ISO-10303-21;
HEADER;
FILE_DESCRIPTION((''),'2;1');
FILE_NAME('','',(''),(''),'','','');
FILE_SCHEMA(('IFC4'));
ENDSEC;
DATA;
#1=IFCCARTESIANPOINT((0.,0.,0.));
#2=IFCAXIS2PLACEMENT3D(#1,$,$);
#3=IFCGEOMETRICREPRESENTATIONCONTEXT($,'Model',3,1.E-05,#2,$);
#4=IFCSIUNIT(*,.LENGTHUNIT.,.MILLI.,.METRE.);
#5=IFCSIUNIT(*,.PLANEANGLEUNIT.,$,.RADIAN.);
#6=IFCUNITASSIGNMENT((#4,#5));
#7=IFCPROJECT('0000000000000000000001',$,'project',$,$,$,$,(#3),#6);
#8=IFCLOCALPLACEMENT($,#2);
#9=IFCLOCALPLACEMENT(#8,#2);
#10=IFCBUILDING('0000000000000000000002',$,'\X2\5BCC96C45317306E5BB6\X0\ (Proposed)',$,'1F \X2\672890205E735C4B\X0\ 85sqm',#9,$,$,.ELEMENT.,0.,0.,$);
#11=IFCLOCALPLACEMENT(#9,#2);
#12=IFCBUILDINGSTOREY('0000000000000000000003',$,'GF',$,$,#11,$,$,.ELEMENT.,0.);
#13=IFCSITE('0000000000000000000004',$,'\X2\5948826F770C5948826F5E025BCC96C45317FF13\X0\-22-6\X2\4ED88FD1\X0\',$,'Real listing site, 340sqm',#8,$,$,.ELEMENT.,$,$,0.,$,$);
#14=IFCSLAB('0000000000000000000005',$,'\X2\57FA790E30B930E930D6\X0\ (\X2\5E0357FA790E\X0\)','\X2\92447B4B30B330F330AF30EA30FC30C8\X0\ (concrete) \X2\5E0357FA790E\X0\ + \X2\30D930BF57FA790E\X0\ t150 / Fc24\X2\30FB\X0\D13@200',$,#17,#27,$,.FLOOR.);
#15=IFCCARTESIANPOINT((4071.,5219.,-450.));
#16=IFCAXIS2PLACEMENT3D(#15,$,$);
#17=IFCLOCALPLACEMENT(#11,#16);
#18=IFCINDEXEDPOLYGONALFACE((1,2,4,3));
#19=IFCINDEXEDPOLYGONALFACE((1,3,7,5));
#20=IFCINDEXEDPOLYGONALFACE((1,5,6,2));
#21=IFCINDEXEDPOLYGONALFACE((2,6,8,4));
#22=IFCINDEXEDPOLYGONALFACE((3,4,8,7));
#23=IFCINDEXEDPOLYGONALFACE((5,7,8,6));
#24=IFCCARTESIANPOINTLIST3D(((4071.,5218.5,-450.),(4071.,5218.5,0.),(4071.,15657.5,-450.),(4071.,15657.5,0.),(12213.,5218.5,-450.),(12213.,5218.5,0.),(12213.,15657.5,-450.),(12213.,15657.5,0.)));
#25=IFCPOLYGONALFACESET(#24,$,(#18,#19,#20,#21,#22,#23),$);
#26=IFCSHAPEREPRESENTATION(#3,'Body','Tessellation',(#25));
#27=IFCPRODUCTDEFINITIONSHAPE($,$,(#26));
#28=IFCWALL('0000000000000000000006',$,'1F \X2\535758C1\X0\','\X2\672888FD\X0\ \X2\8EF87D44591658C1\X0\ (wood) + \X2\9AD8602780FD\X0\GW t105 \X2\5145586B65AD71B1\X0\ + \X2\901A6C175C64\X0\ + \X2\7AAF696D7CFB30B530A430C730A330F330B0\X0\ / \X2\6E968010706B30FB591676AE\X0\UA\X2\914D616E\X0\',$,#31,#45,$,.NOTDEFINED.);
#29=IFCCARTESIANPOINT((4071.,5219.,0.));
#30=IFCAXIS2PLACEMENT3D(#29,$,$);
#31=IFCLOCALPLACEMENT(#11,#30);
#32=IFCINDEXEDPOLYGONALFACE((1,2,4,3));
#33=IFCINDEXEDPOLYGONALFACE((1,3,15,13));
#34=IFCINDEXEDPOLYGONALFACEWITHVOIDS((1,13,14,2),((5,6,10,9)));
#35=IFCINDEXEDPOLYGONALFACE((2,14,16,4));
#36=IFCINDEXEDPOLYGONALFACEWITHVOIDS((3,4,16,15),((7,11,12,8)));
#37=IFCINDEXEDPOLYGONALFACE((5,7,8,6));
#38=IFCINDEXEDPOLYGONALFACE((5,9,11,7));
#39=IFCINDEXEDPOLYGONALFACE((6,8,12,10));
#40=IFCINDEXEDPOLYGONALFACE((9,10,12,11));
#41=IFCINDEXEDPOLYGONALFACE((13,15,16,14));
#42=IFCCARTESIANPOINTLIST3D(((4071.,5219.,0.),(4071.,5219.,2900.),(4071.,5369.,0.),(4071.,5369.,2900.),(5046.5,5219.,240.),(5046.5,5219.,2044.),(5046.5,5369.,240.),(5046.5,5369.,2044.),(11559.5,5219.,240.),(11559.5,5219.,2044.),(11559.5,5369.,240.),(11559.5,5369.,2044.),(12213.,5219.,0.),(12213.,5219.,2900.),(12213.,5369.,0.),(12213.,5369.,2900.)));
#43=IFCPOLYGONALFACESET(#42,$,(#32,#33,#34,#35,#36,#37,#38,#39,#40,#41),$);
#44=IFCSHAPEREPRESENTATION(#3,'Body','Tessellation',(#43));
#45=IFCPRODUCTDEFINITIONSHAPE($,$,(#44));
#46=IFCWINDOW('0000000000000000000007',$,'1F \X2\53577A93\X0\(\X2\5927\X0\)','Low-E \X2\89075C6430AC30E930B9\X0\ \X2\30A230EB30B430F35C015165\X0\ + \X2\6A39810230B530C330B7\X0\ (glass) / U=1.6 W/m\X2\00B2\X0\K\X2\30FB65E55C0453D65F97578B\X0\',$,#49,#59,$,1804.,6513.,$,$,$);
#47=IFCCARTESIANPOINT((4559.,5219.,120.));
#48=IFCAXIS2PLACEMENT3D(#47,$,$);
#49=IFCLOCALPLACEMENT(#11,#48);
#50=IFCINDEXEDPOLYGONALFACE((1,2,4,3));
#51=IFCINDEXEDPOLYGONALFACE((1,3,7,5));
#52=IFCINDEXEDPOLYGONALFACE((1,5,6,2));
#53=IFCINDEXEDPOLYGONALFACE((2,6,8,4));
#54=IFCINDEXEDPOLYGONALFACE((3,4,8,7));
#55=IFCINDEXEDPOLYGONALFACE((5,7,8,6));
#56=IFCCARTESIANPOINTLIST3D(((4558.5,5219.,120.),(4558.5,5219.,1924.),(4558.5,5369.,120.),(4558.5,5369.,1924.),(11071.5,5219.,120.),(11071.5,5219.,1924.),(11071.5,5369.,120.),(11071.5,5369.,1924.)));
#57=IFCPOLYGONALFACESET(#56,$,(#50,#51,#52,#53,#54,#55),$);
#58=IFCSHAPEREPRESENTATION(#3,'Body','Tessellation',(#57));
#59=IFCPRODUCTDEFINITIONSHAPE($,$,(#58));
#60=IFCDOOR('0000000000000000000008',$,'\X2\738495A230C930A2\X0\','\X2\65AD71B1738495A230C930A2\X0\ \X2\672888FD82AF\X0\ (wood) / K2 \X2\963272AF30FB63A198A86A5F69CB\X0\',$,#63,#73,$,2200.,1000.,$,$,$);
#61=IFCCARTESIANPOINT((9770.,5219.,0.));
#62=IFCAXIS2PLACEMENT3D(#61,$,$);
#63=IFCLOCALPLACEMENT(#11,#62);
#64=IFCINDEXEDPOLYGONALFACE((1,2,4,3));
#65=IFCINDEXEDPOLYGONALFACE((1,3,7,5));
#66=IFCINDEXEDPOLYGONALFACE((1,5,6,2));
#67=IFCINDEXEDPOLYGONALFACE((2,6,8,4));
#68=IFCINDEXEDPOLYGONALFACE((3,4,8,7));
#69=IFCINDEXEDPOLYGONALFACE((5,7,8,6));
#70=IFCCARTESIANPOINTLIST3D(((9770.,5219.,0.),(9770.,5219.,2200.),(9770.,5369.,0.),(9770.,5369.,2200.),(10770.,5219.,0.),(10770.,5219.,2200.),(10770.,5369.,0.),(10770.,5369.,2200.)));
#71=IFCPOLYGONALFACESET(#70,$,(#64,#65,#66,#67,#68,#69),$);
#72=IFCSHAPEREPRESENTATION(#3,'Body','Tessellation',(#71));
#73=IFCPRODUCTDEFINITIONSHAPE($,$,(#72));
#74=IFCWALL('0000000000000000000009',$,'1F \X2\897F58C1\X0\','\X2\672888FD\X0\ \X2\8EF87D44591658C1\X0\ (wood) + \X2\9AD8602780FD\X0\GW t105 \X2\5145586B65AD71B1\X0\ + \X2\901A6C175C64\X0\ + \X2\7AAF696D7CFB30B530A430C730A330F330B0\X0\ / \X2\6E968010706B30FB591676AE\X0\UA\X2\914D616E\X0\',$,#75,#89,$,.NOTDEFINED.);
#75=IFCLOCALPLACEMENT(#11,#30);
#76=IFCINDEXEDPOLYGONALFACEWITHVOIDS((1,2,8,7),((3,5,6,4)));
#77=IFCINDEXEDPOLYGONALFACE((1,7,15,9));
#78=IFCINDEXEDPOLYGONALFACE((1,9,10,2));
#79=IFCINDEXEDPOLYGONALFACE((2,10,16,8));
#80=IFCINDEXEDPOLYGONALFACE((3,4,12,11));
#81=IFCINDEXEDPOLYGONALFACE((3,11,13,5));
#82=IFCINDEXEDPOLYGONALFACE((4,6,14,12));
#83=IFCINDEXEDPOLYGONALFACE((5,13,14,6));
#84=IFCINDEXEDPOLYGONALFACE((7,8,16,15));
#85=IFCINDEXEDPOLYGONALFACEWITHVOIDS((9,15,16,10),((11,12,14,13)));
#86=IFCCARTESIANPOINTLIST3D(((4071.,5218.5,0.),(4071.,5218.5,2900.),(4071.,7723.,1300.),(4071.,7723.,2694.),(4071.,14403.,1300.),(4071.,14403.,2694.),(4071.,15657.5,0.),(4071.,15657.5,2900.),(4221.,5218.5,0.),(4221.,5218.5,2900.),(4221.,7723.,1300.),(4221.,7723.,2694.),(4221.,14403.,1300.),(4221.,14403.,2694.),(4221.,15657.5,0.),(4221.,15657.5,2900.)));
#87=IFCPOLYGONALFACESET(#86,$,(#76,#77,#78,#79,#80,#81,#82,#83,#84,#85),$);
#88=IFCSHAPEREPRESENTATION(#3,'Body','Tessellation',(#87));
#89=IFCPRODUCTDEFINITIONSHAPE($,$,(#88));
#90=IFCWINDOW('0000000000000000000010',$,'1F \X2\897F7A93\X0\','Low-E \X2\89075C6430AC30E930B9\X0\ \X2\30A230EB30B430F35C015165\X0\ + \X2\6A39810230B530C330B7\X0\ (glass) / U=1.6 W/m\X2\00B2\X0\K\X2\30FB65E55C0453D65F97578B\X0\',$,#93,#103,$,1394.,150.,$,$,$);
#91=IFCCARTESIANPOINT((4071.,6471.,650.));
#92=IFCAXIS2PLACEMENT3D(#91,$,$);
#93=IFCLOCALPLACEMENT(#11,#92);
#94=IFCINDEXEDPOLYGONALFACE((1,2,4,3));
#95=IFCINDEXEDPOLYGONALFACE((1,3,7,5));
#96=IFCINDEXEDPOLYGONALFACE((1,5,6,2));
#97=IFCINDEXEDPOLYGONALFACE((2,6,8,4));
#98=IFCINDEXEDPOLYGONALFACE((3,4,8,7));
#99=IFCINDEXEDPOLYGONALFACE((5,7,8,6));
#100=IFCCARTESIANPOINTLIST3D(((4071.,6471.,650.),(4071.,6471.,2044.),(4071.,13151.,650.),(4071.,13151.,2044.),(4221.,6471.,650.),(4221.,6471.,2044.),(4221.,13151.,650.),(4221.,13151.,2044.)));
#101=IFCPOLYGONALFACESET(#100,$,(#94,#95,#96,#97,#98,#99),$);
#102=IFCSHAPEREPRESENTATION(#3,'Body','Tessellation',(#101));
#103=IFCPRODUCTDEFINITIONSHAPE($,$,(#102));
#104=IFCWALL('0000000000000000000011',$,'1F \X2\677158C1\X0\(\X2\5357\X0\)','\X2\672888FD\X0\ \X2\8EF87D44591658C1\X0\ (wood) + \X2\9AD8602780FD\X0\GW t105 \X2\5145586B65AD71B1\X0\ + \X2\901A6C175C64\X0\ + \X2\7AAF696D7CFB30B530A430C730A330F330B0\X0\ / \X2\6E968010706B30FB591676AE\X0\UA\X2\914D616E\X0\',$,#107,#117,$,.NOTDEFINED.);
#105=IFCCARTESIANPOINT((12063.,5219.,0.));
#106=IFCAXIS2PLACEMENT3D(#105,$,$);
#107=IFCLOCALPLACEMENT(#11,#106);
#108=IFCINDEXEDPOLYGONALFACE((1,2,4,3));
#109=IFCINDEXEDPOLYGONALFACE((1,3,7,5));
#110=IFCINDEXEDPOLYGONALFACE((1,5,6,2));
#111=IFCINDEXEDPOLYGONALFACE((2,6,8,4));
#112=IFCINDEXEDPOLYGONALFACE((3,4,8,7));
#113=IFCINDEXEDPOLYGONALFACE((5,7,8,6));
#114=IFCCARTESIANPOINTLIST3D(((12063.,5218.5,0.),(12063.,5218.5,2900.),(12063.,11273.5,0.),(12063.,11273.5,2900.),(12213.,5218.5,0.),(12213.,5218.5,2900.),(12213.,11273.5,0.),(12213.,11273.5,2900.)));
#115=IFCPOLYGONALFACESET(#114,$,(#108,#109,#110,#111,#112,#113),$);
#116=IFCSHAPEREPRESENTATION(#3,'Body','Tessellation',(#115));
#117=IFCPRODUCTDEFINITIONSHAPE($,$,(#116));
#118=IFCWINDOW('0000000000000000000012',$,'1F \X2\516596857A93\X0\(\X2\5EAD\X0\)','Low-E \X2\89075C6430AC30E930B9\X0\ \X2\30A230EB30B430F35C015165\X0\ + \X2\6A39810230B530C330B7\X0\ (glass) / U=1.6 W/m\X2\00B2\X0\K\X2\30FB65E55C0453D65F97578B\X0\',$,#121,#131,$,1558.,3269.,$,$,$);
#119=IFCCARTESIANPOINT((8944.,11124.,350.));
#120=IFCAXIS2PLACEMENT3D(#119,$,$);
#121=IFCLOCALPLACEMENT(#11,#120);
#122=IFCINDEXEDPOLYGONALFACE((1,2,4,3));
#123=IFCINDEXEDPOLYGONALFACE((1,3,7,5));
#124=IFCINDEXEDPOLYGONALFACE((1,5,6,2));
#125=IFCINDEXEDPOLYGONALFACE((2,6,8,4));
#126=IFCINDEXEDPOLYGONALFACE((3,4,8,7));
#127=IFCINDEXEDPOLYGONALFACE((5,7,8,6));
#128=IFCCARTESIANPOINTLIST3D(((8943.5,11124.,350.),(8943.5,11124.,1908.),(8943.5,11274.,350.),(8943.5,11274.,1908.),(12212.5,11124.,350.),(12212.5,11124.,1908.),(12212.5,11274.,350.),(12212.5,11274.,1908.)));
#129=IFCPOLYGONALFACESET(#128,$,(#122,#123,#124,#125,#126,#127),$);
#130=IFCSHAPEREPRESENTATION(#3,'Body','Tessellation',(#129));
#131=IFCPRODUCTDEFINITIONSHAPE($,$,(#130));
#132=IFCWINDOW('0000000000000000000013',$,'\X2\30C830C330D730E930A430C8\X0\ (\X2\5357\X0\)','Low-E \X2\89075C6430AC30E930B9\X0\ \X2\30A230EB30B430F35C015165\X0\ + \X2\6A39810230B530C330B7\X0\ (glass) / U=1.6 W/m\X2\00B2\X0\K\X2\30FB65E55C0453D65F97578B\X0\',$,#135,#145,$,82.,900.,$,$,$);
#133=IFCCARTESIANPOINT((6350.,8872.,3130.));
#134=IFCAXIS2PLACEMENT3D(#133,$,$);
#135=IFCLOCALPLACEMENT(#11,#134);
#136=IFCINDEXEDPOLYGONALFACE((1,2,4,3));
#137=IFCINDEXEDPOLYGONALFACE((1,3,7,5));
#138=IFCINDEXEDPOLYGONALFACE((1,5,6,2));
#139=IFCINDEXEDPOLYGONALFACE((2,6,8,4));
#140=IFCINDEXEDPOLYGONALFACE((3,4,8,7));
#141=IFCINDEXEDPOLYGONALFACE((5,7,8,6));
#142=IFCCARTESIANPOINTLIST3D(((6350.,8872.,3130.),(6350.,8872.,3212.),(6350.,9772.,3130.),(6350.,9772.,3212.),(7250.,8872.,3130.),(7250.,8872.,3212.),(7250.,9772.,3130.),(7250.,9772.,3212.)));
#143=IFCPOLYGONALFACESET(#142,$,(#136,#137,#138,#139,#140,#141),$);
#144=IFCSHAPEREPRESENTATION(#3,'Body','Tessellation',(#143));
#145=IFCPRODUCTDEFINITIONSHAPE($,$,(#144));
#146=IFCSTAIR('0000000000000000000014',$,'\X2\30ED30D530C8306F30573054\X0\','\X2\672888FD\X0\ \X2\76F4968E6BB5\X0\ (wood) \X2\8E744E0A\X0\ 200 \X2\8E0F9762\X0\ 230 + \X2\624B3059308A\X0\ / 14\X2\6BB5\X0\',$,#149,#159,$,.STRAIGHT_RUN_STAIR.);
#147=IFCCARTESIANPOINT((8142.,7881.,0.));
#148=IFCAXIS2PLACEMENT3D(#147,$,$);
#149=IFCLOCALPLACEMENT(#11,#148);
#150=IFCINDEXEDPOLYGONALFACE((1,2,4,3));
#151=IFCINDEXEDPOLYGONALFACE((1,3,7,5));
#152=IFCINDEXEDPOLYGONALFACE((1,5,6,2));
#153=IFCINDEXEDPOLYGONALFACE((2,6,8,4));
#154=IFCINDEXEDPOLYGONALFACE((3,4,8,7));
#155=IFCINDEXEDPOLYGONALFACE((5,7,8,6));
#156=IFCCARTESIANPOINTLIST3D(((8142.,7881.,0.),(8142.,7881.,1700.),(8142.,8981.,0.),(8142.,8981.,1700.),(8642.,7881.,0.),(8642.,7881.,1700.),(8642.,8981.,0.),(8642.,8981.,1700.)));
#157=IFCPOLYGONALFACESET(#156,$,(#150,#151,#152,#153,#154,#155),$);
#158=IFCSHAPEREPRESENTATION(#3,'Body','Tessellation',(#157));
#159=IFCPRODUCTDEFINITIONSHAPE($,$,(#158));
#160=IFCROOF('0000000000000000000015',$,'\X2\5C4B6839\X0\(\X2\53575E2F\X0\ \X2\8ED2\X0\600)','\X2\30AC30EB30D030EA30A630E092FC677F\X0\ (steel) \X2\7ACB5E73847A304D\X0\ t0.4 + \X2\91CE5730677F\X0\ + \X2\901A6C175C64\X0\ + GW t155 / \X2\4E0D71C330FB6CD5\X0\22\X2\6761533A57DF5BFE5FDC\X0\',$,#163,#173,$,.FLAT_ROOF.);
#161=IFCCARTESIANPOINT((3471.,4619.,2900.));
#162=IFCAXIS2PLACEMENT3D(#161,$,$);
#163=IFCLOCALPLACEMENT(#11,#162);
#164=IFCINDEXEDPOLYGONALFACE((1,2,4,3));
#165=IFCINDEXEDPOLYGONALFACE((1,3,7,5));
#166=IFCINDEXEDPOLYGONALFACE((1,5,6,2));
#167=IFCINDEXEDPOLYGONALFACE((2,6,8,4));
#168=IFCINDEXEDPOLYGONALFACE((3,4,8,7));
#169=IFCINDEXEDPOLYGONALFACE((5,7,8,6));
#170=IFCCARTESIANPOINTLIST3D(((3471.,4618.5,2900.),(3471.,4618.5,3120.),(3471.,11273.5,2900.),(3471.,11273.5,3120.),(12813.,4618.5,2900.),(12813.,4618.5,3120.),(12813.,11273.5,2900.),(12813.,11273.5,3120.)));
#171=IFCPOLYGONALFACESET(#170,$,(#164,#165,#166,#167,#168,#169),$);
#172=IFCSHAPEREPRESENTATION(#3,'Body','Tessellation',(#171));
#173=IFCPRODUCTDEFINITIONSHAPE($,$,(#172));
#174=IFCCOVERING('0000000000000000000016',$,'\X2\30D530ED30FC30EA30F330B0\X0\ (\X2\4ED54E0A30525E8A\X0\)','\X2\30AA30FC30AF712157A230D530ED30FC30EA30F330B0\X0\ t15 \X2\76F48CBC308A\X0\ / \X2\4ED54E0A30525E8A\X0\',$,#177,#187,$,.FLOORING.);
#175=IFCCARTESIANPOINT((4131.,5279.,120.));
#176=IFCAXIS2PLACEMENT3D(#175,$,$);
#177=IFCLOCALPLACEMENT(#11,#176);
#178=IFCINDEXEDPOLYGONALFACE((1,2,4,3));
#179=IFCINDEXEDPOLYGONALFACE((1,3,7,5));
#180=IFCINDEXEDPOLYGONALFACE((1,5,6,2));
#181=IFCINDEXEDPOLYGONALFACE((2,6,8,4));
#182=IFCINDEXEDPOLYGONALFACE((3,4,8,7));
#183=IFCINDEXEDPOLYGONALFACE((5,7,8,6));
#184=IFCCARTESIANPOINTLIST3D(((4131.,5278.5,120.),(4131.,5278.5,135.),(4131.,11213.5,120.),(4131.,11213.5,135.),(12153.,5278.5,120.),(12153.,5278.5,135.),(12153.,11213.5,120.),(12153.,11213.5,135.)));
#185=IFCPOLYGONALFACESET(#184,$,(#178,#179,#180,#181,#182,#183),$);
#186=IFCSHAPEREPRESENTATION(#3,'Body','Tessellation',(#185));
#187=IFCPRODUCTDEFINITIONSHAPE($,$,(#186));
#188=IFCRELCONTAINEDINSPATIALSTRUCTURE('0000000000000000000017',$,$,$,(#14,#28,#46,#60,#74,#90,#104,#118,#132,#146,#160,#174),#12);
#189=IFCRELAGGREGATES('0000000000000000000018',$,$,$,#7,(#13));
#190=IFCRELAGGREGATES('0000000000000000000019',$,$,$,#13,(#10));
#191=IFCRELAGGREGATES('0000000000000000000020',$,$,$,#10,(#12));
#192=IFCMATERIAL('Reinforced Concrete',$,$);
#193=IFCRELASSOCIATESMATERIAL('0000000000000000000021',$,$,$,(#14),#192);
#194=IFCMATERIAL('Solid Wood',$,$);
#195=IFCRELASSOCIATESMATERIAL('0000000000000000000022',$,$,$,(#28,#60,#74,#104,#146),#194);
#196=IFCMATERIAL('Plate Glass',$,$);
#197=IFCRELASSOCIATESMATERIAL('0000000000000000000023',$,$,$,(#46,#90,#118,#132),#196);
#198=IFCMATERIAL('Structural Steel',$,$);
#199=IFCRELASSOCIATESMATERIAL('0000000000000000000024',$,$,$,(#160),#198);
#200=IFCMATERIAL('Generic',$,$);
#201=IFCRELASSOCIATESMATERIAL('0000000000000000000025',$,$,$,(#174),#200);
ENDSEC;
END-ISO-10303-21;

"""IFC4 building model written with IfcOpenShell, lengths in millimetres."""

from ifc_helpers import new_model, si_unit, frame, frame_2d, origin, place, context, project, spatial, rectangle, extrude, material, element, fill, save


model = new_model("IFC4")

# Units and contexts
model_context = context("Model", 3, precision=1e-05, world=origin())
ifc_project = project(units=[si_unit("LENGTHUNIT", "METRE", prefix="MILLI"), si_unit("PLANEANGLEUNIT", "RADIAN")], contexts=[model_context])

# Site, building, storey
site_placement = place(None, origin())
site = spatial("IfcSite", under=ifc_project, at=site_placement, Name="奈良県奈良市富雄北３-22-6付近", ObjectType="Real listing site, 340sqm", CompositionType="ELEMENT", RefElevation=0.0)
building_placement = place(site_placement, origin())
building = spatial("IfcBuilding", under=site, at=building_placement, Name="富雄北の家 (Proposed)", ObjectType="1F 木造平屋 85sqm", CompositionType="ELEMENT", ElevationOfRefHeight=0.0, ElevationOfTerrain=0.0)
storey_placement = place(building_placement, origin())
storey = spatial("IfcBuildingStorey", under=building, at=storey_placement, Name="GF", CompositionType="ELEMENT", Elevation=0.0)

# Slab
ifc_material_1 = material(Name="Reinforced Concrete")
slab_1_placement = place(storey_placement, frame((4071.0, 5219.0, -450.0)))
element("IfcSlab", 1, at=slab_1_placement, inside=storey, material=ifc_material_1, Name="基礎スラブ (布基礎)", Description="鉄筋コンクリート (concrete) 布基礎 + ベタ基礎 t150 / Fc24・D13@200", PredefinedType="FLOOR", context=model_context, shape_type="SweptSolid", body=[
    extrude(rectangle(XDim=8142.0, YDim=10439.0, at=frame_2d((4071.0, 5219.0))), frame((4071.0, 5219.0, -450.0)), (0.0, 0.0, 1.0), 450.0),
])
ifc_material_2 = material(Name="Solid Wood")

# Wall, openings, window, door
wall_1_placement = place(storey_placement, frame((4071.0, 5219.0, 0.0)))
wall_1 = element("IfcWall", 2, at=wall_1_placement, inside=storey, material=ifc_material_2, Name="1F 南壁", Description="木製 軸組外壁 (wood) + 高性能GW t105 充填断熱 + 通気層 + 窯業系サイディング / 準耐火・外皮UA配慮", PredefinedType="NOTDEFINED", context=model_context, shape_type="SweptSolid", body=[
    extrude(rectangle(XDim=8142.0, YDim=150.0, at=frame_2d((4071.0, 75.0))), frame((4071.0, 5219.0, 0.0)), (0.0, 0.0, 1.0), 2900.0),
])
opening_1_placement = place(storey_placement, frame((4559.0, 5219.0, 120.0)))
opening_1 = element("IfcOpeningElement", 3, at=opening_1_placement, cuts=wall_1, PredefinedType="NOTDEFINED", context=model_context, shape_type="SweptSolid", body=[
    extrude(rectangle(XDim=6513.0, YDim=150.0, at=frame_2d((3256.0, 75.0))), frame((4559.0, 5219.0, 120.0)), (0.0, 0.0, 1.0), 1804.0),
])
opening_2_placement = place(storey_placement, frame((9770.0, 5219.0, 0.0)))
opening_2 = element("IfcOpeningElement", 4, at=opening_2_placement, cuts=wall_1, PredefinedType="NOTDEFINED", context=model_context, shape_type="SweptSolid", body=[
    extrude(rectangle(XDim=1000.0, YDim=150.0, at=frame_2d((500.0, 75.0))), frame((9770.0, 5219.0, 0.0)), (0.0, 0.0, 1.0), 2200.0),
])
ifc_material_3 = material(Name="Plate Glass")
window_1_placement = place(storey_placement, frame((4559.0, 5219.0, 120.0)))
window_1 = element("IfcWindow", 5, at=window_1_placement, inside=storey, material=ifc_material_3, Name="1F 南窓(大)", Description="Low-E 複層ガラス アルゴン封入 + 樹脂サッシ (glass) / U=1.6 W/m²K・日射取得型", OverallHeight=1804.0, OverallWidth=6513.0, context=model_context, shape_type="SweptSolid", body=[
    extrude(rectangle(XDim=6513.0, YDim=150.0, at=frame_2d((3256.0, 75.0))), frame((4559.0, 5219.0, 120.0)), (0.0, 0.0, 1.0), 1804.0),
])
fill(opening_1, window_1)
door_1_placement = place(storey_placement, frame((9770.0, 5219.0, 0.0)))
door_1 = element("IfcDoor", 6, at=door_1_placement, inside=storey, material=ifc_material_2, Name="玄関ドア", Description="断熱玄関ドア 木製芯 (wood) / K2 防犯・採風機構", OverallHeight=2200.0, OverallWidth=1000.0, context=model_context, shape_type="SweptSolid", body=[
    extrude(rectangle(XDim=1000.0, YDim=150.0, at=frame_2d((500.0, 75.0))), frame((9770.0, 5219.0, 0.0)), (0.0, 0.0, 1.0), 2200.0),
])
fill(opening_2, door_1)

# Walls, openings, windows
wall_2_placement = place(storey_placement, frame((4071.0, 5219.0, 0.0)))
wall_2 = element("IfcWall", 7, at=wall_2_placement, inside=storey, material=ifc_material_2, Name="1F 西壁", Description="木製 軸組外壁 (wood) + 高性能GW t105 充填断熱 + 通気層 + 窯業系サイディング / 準耐火・外皮UA配慮", PredefinedType="NOTDEFINED", context=model_context, shape_type="SweptSolid", body=[
    extrude(rectangle(XDim=150.0, YDim=10439.0, at=frame_2d((75.0, 5219.0))), frame((4071.0, 5219.0, 0.0)), (0.0, 0.0, 1.0), 2900.0),
])
opening_3_placement = place(storey_placement, frame((4071.0, 6471.0, 650.0)))
opening_3 = element("IfcOpeningElement", 8, at=opening_3_placement, cuts=wall_2, PredefinedType="NOTDEFINED", context=model_context, shape_type="SweptSolid", body=[
    extrude(rectangle(XDim=150.0, YDim=6680.0, at=frame_2d((75.0, 3340.0))), frame((4071.0, 6471.0, 650.0)), (0.0, 0.0, 1.0), 1394.0),
])
window_2_placement = place(storey_placement, frame((4071.0, 6471.0, 650.0)))
window_2 = element("IfcWindow", 9, at=window_2_placement, inside=storey, material=ifc_material_3, Name="1F 西窓", Description="Low-E 複層ガラス アルゴン封入 + 樹脂サッシ (glass) / U=1.6 W/m²K・日射取得型", OverallHeight=1394.0, OverallWidth=150.0, context=model_context, shape_type="SweptSolid", body=[
    extrude(rectangle(XDim=150.0, YDim=6680.0, at=frame_2d((75.0, 3340.0))), frame((4071.0, 6471.0, 650.0)), (0.0, 0.0, 1.0), 1394.0),
])
fill(opening_3, window_2)
wall_3_placement = place(storey_placement, frame((12063.0, 5219.0, 0.0)))
wall_3 = element("IfcWall", 10, at=wall_3_placement, inside=storey, material=ifc_material_2, Name="1F 東壁(南)", Description="木製 軸組外壁 (wood) + 高性能GW t105 充填断熱 + 通気層 + 窯業系サイディング / 準耐火・外皮UA配慮", PredefinedType="NOTDEFINED", context=model_context, shape_type="SweptSolid", body=[
    extrude(rectangle(XDim=150.0, YDim=6055.0, at=frame_2d((75.0, 3027.0))), frame((12063.0, 5219.0, 0.0)), (0.0, 0.0, 1.0), 2900.0),
])
opening_4_placement = place(storey_placement, frame((8944.0, 11124.0, 350.0)))
opening_4 = element("IfcOpeningElement", 11, at=opening_4_placement, cuts=wall_3, PredefinedType="NOTDEFINED", context=model_context, shape_type="SweptSolid", body=[
    extrude(rectangle(XDim=3269.0, YDim=150.0, at=frame_2d((1634.0, 75.0))), frame((8944.0, 11124.0, 350.0)), (0.0, 0.0, 1.0), 1558.0),
])
window_3_placement = place(storey_placement, frame((8944.0, 11124.0, 350.0)))
window_3 = element("IfcWindow", 12, at=window_3_placement, inside=storey, material=ifc_material_3, Name="1F 入隅窓(庭)", Description="Low-E 複層ガラス アルゴン封入 + 樹脂サッシ (glass) / U=1.6 W/m²K・日射取得型", OverallHeight=1558.0, OverallWidth=3269.0, context=model_context, shape_type="SweptSolid", body=[
    extrude(rectangle(XDim=3269.0, YDim=150.0, at=frame_2d((1634.0, 75.0))), frame((8944.0, 11124.0, 350.0)), (0.0, 0.0, 1.0), 1558.0),
])
fill(opening_4, window_3)

# Window
window_4_placement = place(storey_placement, frame((6350.0, 8872.0, 3130.0)))
element("IfcWindow", 13, at=window_4_placement, inside=storey, material=ifc_material_3, Name="トップライト (南)", Description="Low-E 複層ガラス アルゴン封入 + 樹脂サッシ (glass) / U=1.6 W/m²K・日射取得型", OverallHeight=82.0, OverallWidth=900.0, context=model_context, shape_type="SweptSolid", body=[
    extrude(rectangle(XDim=900.0, YDim=900.0, at=frame_2d((450.0, 450.0))), frame((6350.0, 8872.0, 3130.0)), (0.0, 0.0, 1.0), 82.0),
])

# Stair
stair_placement = place(storey_placement, frame((8142.0, 7881.0, 0.0)))
element("IfcStair", 14, at=stair_placement, inside=storey, material=ifc_material_2, Name="ロフトはしご", Description="木製 直階段 (wood) 蹴上 200 踏面 230 + 手すり / 14段", PredefinedType="STRAIGHT_RUN_STAIR", context=model_context, shape_type="SweptSolid", body=[
    extrude(rectangle(XDim=500.0, YDim=1100.0, at=frame_2d((250.0, 550.0))), frame((8142.0, 7881.0, 0.0)), (0.0, 0.0, 1.0), 1700.0),
])

# Roof
ifc_material_4 = material(Name="Structural Steel")
roof_placement = place(storey_placement, frame((3471.0, 4619.0, 2900.0)))
element("IfcRoof", 15, at=roof_placement, inside=storey, material=ifc_material_4, Name="屋根(南帯 軒600)", Description="ガルバリウム鋼板 (steel) 立平葺き t0.4 + 野地板 + 通気層 + GW t155 / 不燃・法22条区域対応", PredefinedType="FLAT_ROOF", context=model_context, shape_type="SweptSolid", body=[
    extrude(rectangle(XDim=9342.0, YDim=6655.0, at=frame_2d((4671.0, 3327.0))), frame((3471.0, 4619.0, 2900.0)), (0.0, 0.0, 1.0), 220.0),
])

# Covering
ifc_material_5 = material(Name="Generic")
covering_placement = place(storey_placement, frame((4131.0, 5279.0, 120.0)))
element("IfcCovering", 16, at=covering_placement, inside=storey, material=ifc_material_5, Name="フローリング (仕上げ床)", Description="オーク無垢フローリング t15 直貼り / 仕上げ床", PredefinedType="FLOORING", context=model_context, shape_type="SweptSolid", body=[
    extrude(rectangle(XDim=8022.0, YDim=5935.0, at=frame_2d((4011.0, 2967.0))), frame((4131.0, 5279.0, 120.0)), (0.0, 0.0, 1.0), 15.0),
])

save(model, "model.ifc")
